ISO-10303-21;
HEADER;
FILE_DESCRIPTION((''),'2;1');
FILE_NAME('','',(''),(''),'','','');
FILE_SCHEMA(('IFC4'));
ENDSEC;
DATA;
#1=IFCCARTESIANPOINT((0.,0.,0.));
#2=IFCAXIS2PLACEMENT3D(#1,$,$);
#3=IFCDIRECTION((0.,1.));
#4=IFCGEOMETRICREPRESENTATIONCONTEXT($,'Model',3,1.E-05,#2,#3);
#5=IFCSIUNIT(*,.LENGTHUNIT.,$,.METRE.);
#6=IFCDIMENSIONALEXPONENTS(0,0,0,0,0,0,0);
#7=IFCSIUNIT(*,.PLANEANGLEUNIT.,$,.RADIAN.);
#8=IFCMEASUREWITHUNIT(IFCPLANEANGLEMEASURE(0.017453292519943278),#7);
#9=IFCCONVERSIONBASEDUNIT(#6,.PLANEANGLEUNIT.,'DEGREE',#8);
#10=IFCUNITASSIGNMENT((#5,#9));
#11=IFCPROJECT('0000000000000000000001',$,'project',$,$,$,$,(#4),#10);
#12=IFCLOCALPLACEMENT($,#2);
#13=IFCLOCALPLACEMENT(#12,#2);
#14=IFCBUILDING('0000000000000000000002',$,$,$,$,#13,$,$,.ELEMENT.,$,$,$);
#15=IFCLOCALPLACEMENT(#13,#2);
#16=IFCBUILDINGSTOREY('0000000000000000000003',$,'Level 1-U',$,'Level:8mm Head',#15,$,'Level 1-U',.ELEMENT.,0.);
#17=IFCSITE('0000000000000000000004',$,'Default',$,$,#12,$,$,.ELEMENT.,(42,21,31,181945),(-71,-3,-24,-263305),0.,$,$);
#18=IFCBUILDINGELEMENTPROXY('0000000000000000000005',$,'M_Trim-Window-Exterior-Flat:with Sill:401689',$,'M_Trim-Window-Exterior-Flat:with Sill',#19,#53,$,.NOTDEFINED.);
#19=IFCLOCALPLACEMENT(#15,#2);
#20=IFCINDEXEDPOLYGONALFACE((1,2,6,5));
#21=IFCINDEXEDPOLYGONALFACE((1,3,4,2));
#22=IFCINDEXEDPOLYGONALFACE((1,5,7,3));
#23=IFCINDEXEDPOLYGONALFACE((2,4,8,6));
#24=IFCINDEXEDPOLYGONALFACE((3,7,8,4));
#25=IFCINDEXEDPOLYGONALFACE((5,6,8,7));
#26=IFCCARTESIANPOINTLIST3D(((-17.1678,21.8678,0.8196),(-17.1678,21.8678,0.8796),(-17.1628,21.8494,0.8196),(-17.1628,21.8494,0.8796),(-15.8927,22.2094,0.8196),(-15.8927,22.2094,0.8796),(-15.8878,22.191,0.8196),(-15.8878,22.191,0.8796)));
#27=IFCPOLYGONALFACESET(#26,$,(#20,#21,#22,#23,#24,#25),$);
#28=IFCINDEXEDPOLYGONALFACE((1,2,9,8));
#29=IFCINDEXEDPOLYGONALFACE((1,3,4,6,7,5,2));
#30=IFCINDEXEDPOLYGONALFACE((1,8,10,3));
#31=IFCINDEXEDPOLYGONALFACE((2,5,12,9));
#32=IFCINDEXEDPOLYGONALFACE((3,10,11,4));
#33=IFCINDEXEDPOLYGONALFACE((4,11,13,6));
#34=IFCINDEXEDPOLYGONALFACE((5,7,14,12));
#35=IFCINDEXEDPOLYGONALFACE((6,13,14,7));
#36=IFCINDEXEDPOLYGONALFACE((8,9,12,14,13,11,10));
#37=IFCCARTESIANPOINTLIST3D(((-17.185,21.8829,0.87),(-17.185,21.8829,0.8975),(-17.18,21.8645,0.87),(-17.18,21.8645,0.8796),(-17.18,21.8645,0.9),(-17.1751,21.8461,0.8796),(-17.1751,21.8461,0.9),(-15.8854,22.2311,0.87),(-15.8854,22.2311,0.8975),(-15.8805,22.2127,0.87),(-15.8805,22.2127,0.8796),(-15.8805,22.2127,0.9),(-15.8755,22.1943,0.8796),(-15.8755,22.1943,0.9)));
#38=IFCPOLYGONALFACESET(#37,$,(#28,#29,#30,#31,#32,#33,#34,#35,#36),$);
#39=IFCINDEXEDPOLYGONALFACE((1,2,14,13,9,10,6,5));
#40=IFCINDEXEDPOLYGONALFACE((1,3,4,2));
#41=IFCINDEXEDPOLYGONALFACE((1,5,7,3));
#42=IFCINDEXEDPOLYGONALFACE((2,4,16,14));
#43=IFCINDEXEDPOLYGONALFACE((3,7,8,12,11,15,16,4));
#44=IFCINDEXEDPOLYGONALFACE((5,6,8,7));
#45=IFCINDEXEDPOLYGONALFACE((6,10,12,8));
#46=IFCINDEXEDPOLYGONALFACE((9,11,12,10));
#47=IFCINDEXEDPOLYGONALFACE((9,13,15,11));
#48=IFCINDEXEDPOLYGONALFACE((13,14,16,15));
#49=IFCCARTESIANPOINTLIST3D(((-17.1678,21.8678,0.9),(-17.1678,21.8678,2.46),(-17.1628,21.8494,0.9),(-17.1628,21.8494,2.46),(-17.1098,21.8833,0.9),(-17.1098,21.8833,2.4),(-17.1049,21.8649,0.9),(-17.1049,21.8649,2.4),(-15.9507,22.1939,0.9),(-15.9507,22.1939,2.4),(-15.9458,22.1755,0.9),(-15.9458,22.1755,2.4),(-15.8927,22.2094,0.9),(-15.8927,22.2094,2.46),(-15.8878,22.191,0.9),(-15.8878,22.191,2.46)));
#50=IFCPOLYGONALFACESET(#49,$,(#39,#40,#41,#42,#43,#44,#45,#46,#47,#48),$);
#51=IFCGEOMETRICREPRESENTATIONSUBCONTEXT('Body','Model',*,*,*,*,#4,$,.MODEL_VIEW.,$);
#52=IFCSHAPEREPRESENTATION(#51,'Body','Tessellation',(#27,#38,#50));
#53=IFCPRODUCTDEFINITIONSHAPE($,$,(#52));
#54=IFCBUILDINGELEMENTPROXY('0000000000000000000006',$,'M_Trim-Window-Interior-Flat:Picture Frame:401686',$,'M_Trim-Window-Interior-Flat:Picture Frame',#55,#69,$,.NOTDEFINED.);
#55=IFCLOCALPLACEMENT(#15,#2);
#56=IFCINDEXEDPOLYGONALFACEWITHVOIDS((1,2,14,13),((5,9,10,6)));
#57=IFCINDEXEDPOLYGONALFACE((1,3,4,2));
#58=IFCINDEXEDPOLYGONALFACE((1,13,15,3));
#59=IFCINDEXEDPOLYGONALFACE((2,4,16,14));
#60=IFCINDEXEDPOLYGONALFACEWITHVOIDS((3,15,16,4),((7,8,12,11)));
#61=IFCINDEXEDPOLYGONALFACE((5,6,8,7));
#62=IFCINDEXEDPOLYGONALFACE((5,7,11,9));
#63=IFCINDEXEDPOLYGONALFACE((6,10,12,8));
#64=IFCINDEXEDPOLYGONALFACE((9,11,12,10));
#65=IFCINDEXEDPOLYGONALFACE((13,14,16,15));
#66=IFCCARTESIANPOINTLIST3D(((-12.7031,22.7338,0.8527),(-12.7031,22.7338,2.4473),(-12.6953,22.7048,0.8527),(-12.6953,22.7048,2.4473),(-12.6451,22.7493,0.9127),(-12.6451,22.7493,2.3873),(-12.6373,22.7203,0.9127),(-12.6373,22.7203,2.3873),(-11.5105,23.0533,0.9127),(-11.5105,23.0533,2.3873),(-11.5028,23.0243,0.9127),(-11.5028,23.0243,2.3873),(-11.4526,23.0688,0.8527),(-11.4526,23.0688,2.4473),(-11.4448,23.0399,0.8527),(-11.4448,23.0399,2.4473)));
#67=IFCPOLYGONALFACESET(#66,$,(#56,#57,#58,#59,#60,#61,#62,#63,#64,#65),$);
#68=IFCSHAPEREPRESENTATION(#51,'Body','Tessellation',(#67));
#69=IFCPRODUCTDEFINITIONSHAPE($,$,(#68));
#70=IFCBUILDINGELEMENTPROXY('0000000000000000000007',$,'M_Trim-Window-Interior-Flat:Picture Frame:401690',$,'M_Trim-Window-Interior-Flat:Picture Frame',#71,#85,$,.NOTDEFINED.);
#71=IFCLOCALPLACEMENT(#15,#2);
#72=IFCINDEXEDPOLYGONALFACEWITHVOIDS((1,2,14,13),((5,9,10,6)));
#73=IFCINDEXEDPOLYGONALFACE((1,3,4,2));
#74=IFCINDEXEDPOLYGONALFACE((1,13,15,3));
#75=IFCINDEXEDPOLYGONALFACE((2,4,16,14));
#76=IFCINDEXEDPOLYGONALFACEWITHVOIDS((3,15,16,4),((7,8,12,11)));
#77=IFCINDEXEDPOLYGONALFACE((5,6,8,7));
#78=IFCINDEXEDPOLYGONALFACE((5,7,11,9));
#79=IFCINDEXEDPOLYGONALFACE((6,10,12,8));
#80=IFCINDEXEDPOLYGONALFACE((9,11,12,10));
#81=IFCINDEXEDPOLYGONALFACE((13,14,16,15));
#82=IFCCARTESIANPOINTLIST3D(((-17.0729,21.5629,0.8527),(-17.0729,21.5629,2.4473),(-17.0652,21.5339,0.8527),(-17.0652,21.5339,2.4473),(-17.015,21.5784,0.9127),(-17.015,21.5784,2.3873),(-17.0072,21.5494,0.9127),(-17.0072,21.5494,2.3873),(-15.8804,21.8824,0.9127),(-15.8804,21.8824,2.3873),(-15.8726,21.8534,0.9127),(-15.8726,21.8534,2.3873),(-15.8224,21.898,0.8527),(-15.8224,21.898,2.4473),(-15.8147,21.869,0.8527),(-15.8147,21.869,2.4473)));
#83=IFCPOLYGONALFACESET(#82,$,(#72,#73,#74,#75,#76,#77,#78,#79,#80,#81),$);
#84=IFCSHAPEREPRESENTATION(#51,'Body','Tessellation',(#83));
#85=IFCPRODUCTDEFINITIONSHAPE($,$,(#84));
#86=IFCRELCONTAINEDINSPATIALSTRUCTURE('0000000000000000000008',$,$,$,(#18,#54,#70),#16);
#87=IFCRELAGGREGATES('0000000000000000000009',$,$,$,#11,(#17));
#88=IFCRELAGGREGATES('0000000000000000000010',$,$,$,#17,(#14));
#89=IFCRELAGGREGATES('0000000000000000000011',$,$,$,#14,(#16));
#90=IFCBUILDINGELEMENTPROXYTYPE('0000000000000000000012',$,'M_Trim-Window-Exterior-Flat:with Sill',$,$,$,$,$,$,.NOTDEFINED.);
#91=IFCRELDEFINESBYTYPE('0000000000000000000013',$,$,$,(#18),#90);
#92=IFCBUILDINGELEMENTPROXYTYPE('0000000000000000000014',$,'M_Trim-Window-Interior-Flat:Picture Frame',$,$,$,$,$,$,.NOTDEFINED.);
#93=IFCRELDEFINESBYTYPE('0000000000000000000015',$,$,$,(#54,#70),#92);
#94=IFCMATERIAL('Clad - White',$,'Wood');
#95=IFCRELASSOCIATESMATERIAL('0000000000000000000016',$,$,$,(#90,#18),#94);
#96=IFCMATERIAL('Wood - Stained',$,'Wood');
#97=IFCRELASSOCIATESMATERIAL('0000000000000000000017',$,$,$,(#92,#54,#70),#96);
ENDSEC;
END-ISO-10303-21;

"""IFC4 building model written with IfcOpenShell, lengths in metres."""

from ifc_helpers import new_model, entity, si_unit, converted_unit, direction, frame, frame_2d, origin, place, context, subcontext, project, spatial, polyline, rectangle, outline, extrude, source, transform, mapped, material, type_object, type_shapes, element, save


model = new_model("IFC4")

# Units and contexts
model_context = context("Model", 3, precision=1e-05, world=origin(), true_north=direction((0.0, 1.0)))
body_context = subcontext(model_context, "Body", "Model", "MODEL_VIEW")
ifc_project = project(units=[si_unit("LENGTHUNIT", "METRE"), converted_unit("PLANEANGLEUNIT", "DEGREE", entity("IfcPlaneAngleMeasure", 0.017453292519943278), si_unit("PLANEANGLEUNIT", "RADIAN"), dimensions=[0, 0, 0, 0, 0, 0, 0])], contexts=[model_context])

# Site, building, storey
site_placement = place(None, origin())
site = spatial("IfcSite", under=ifc_project, at=site_placement, Name="Default", CompositionType="ELEMENT", RefLatitude=(42, 21, 31, 181945), RefLongitude=(-71, -3, -24, -263305), RefElevation=0.0)
building_placement = place(site_placement, origin())
building = spatial("IfcBuilding", under=site, at=building_placement, CompositionType="ELEMENT")
storey_placement = place(building_placement, origin())
storey = spatial("IfcBuildingStorey", under=building, at=storey_placement, Name="Level 1-U", ObjectType="Level:8mm Head", LongName="Level 1-U", CompositionType="ELEMENT", Elevation=0.0)

# Building element proxies
ifc_material_1 = material(Name="Clad - White", Category="Wood")
ifc_material_2 = material(Name="Wood - Stained", Category="Wood")
building_element_proxy_type_1 = type_object("IfcBuildingElementProxyType", Name="M_Trim-Window-Exterior-Flat:with Sill", PredefinedType="NOTDEFINED", material=ifc_material_1)
shared_shape_1 = source(origin(), body_context, "Body", "SweptSolid", [
    extrude(rectangle(XDim=1.32, YDim=0.06, at=frame_2d((0.0, 0.0), x_axis=(1.0, 0.0))), frame((0.0, -1.5504, 0.0), z_axis=(0.0, 0.0, 1.0), x_axis=(-1.0, 0.0, 0.0)), (0.0, 0.0, 1.0), 0.019),
    extrude(outline(polyline([(-0.019, -0.0152), (0.0, -0.0152), (0.0, -0.0057), (0.019, -0.0057), (0.019, 0.0148), (0.0, 0.0148), (-0.019, 0.0123), (-0.019, -0.0152)])), frame((-0.6727, -1.5148, 0.019), z_axis=(1.0, 0.0, 0.0), x_axis=(0.0, 0.0, -1.0)), (0.0, 0.0, 1.0), 1.3454),
    extrude(outline(polyline([(-0.795, -0.66), (0.765, -0.66), (0.765, -0.6), (-0.735, -0.6), (-0.735, 0.6), (0.765, 0.6), (0.765, 0.66), (-0.795, 0.66), (-0.795, -0.66)])), frame((0.0, -0.735, 0.0), z_axis=(0.0, 0.0, 1.0), x_axis=(0.0, -1.0, 0.0)), (0.0, 0.0, 1.0), 0.019),
])
type_shapes(building_element_proxy_type_1, [shared_shape_1])
for number, where, z_axis, x_axis, name in (
    (1, (-16.5253, 22.0202, 2.4), (-0.258819, 0.965926, 0.0), (-0.965926, -0.258819, 0.0), "M_Trim-Window-Exterior-Flat:with Sill:401689"),
):
    element("IfcBuildingElementProxy", number, at=place(storey_placement, frame(where, z_axis=z_axis, x_axis=x_axis)), inside=storey, type_object=building_element_proxy_type_1, material=ifc_material_1, Name=name, ObjectType="M_Trim-Window-Exterior-Flat:with Sill", PredefinedType="NOTDEFINED", context=body_context, shape_type="MappedRepresentation", body=[
        mapped(shared_shape_1, transform((0.0, 0.0, 0.0), scale=1.0)),
    ])
building_element_proxy_type_2 = type_object("IfcBuildingElementProxyType", Name="M_Trim-Window-Interior-Flat:Picture Frame", PredefinedType="NOTDEFINED", material=ifc_material_2)
shared_shape_2 = source(origin(), body_context, "Body", "SweptSolid", [
    extrude(outline(polyline([(-0.6473, -0.7973), (0.6473, -0.7973), (0.6473, 0.7973), (-0.6473, 0.7973), (-0.6473, -0.7973)]), holes=[polyline([(-0.5873, -0.7373), (-0.5873, 0.7373), (0.5873, 0.7373), (0.5873, -0.7373), (-0.5873, -0.7373)])]), frame((0.0, -0.75, 0.0), z_axis=(0.0, 0.0, 1.0), x_axis=(-1.0, 0.0, 0.0)), (0.0, 0.0, 1.0), 0.03),
])
type_shapes(building_element_proxy_type_2, [shared_shape_2])
for number, where, z_axis, x_axis, name in (
    (2, (-12.0778, 22.9013, 2.4), (0.258819, -0.965926, 0.0), (0.965926, 0.258819, 0.0), "M_Trim-Window-Interior-Flat:Picture Frame:401686"),
    (3, (-16.4477, 21.7304, 2.4), (0.258819, -0.965926, 0.0), (0.965926, 0.258819, 0.0), "M_Trim-Window-Interior-Flat:Picture Frame:401690"),
):
    element("IfcBuildingElementProxy", number, at=place(storey_placement, frame(where, z_axis=z_axis, x_axis=x_axis)), inside=storey, type_object=building_element_proxy_type_2, material=ifc_material_2, Name=name, ObjectType="M_Trim-Window-Interior-Flat:Picture Frame", PredefinedType="NOTDEFINED", context=body_context, shape_type="MappedRepresentation", body=[
        mapped(shared_shape_2, transform((0.0, 0.0, 0.0), scale=1.0)),
    ])

save(model, "model.ifc")
